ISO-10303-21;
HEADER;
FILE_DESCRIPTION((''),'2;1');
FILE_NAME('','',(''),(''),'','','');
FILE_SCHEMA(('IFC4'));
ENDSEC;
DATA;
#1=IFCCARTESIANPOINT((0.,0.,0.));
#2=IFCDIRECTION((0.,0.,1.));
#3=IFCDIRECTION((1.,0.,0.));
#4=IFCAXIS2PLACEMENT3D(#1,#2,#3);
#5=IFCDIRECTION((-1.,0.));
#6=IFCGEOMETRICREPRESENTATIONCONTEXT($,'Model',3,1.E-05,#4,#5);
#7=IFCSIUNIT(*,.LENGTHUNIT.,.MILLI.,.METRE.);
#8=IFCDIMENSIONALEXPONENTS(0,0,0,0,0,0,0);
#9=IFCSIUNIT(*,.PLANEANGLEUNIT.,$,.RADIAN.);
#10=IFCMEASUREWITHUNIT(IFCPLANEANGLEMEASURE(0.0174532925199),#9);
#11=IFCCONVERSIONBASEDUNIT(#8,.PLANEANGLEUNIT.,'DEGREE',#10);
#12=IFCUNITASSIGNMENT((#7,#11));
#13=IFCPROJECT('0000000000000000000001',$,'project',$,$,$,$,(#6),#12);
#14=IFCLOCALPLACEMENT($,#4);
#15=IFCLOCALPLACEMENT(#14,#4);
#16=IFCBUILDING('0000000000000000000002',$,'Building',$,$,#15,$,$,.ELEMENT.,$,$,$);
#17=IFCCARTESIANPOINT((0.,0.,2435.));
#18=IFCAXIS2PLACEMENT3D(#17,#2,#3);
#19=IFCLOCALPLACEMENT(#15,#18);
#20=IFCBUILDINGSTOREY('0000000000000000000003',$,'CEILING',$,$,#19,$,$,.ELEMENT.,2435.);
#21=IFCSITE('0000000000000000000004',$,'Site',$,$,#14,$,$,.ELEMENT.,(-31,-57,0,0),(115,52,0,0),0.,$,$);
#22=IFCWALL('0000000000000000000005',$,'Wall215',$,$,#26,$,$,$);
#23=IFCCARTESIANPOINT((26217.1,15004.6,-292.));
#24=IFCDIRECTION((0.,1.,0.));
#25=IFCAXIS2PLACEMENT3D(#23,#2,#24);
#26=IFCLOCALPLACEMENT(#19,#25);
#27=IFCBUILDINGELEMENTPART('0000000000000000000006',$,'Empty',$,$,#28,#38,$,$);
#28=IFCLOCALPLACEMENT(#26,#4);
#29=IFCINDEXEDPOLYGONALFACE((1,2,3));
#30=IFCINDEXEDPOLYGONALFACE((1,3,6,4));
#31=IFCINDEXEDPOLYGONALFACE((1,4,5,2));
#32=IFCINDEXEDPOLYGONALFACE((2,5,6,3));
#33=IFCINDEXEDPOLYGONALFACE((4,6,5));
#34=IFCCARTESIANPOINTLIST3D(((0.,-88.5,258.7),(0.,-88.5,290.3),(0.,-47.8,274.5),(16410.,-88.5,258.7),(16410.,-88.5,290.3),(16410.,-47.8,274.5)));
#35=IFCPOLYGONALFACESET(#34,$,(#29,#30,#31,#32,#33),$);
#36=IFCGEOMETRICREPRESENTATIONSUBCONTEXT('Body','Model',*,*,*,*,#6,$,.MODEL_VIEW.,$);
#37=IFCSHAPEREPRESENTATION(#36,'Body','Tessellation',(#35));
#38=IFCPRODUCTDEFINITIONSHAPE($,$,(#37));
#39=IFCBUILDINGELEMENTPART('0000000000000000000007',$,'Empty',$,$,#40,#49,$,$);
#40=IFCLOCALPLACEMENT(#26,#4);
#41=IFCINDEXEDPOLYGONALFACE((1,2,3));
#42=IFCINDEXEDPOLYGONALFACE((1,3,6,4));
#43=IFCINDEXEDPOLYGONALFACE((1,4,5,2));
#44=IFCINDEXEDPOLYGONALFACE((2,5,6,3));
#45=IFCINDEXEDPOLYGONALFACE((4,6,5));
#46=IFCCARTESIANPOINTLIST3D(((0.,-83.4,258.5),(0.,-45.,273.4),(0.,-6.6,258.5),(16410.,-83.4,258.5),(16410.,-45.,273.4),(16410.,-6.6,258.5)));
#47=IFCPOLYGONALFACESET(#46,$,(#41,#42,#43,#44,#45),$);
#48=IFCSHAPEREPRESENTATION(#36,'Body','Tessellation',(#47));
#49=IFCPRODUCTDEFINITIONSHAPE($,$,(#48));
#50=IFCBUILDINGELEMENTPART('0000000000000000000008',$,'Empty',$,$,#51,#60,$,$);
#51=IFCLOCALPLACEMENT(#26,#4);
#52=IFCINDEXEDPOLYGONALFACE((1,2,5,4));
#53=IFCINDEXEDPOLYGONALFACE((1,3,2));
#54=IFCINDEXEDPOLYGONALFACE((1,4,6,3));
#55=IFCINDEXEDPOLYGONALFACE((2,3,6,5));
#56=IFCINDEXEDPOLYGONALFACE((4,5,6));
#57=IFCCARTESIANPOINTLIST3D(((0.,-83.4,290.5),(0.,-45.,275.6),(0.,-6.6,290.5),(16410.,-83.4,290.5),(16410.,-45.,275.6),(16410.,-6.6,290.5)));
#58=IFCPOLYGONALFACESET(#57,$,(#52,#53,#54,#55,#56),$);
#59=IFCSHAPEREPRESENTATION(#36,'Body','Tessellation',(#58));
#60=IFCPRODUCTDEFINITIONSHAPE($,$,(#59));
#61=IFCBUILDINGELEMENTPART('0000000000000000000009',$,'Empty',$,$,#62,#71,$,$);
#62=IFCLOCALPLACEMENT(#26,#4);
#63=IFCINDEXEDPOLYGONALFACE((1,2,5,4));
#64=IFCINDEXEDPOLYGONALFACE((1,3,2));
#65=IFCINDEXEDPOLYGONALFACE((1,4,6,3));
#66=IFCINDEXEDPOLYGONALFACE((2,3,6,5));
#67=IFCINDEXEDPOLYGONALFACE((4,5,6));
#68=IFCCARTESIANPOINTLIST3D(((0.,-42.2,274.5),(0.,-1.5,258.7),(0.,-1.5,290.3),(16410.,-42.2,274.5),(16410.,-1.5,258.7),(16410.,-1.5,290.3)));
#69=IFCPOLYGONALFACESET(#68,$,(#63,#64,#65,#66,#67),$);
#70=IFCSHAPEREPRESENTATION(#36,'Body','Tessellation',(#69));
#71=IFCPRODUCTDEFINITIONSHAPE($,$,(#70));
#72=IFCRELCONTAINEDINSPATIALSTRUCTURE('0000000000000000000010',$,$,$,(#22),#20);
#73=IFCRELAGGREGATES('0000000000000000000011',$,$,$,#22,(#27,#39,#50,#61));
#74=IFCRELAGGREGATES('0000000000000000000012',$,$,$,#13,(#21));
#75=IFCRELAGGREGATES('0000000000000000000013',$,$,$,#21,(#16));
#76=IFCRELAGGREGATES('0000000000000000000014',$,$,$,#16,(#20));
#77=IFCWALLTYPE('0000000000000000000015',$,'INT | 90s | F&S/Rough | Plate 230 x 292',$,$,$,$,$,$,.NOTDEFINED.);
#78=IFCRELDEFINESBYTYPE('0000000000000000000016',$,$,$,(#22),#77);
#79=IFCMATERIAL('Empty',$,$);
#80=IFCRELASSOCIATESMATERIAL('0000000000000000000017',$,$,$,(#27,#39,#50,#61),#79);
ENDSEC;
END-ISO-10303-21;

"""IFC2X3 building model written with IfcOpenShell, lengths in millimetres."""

from ifc_helpers import new_model, entity, si_unit, converted_unit, direction, frame, origin_with_axes, place, context, subcontext, project, spatial, polyline, outline, extrude, material, type_object, element, aggregate, save


model = new_model("IFC2X3")

# Units and contexts
model_context = context("Model", 3, precision=1e-05, world=origin_with_axes(), true_north=direction((-1.0, 0.0)))
body_context = subcontext(model_context, "Body", "Model", "MODEL_VIEW")
ifc_project = project(units=[si_unit("LENGTHUNIT", "METRE", prefix="MILLI"), converted_unit("PLANEANGLEUNIT", "DEGREE", entity("IfcPlaneAngleMeasure", 0.0174532925199), si_unit("PLANEANGLEUNIT", "RADIAN"), dimensions=[0, 0, 0, 0, 0, 0, 0])], contexts=[model_context])

# Site, building, storey
site_placement = place(None, origin_with_axes())
site = spatial("IfcSite", under=ifc_project, at=site_placement, Name="Site", CompositionType="ELEMENT", RefLatitude=(-31, -57, 0, 0), RefLongitude=(115, 52, 0, 0), RefElevation=0.0)
building_placement = place(site_placement, origin_with_axes())
building = spatial("IfcBuilding", under=site, at=building_placement, Name="Building", CompositionType="ELEMENT")
storey_placement = place(building_placement, frame((0.0, 0.0, 2435.0), z_axis=(0.0, 0.0, 1.0), x_axis=(1.0, 0.0, 0.0)))
storey = spatial("IfcBuildingStorey", under=building, at=storey_placement, Name="CEILING", CompositionType="ELEMENT", Elevation=2435.0)

# Wall, building element parts
wall_type = type_object("IfcWallType", Name="INT | 90s | F&S/Rough | Plate 230 x 292", PredefinedType="NOTDEFINED")
ifc_material_1 = material(Name="Empty")
wall_1_placement = place(storey_placement, frame((26217.1, 15004.6, -292.0), z_axis=(0.0, 0.0, 1.0), x_axis=(0.0, 1.0, 0.0)))
wall_1 = element("IfcWall", 1, at=wall_1_placement, inside=storey, type_object=wall_type, Name="Wall215")
building_element_part_1_placement = place(wall_1_placement, origin_with_axes())
building_element_part_1 = element("IfcBuildingElementPart", 2, at=building_element_part_1_placement, material=ifc_material_1, Name="Empty", context=body_context, shape_type="SweptSolid", body=[
    extrude(outline(polyline([(-47.8, 274.5), (-88.5, 290.3), (-88.5, 258.7), (-47.8, 274.5)])), frame((0.0, 0.0, 0.0), z_axis=(1.0, 0.0, 0.0), x_axis=(0.0, 1.0, 0.0)), (0.0, 0.0, 1.0), 16410.0),
])
building_element_part_2_placement = place(wall_1_placement, origin_with_axes())
building_element_part_2 = element("IfcBuildingElementPart", 3, at=building_element_part_2_placement, material=ifc_material_1, Name="Empty", context=body_context, shape_type="SweptSolid", body=[
    extrude(outline(polyline([(-6.6, 258.5), (-45.0, 273.4), (-83.4, 258.5), (-6.6, 258.5)])), frame((0.0, 0.0, 0.0), z_axis=(1.0, 0.0, 0.0), x_axis=(0.0, 1.0, 0.0)), (0.0, 0.0, 1.0), 16410.0),
])
building_element_part_3_placement = place(wall_1_placement, origin_with_axes())
building_element_part_3 = element("IfcBuildingElementPart", 4, at=building_element_part_3_placement, material=ifc_material_1, Name="Empty", context=body_context, shape_type="SweptSolid", body=[
    extrude(outline(polyline([(-45.0, 275.6), (-6.6, 290.5), (-83.4, 290.5), (-45.0, 275.6)])), frame((0.0, 0.0, 0.0), z_axis=(1.0, 0.0, 0.0), x_axis=(0.0, 1.0, 0.0)), (0.0, 0.0, 1.0), 16410.0),
])
building_element_part_4_placement = place(wall_1_placement, origin_with_axes())
building_element_part_4 = element("IfcBuildingElementPart", 5, at=building_element_part_4_placement, material=ifc_material_1, Name="Empty", context=body_context, shape_type="SweptSolid", body=[
    extrude(outline(polyline([(-42.2, 274.5), (-1.5, 258.7), (-1.5, 290.3), (-42.2, 274.5)])), frame((0.0, 0.0, 0.0), z_axis=(1.0, 0.0, 0.0), x_axis=(0.0, 1.0, 0.0)), (0.0, 0.0, 1.0), 16410.0),
])
aggregate(wall_1, [building_element_part_1, building_element_part_2, building_element_part_3, building_element_part_4])

save(model, "model.ifc")
